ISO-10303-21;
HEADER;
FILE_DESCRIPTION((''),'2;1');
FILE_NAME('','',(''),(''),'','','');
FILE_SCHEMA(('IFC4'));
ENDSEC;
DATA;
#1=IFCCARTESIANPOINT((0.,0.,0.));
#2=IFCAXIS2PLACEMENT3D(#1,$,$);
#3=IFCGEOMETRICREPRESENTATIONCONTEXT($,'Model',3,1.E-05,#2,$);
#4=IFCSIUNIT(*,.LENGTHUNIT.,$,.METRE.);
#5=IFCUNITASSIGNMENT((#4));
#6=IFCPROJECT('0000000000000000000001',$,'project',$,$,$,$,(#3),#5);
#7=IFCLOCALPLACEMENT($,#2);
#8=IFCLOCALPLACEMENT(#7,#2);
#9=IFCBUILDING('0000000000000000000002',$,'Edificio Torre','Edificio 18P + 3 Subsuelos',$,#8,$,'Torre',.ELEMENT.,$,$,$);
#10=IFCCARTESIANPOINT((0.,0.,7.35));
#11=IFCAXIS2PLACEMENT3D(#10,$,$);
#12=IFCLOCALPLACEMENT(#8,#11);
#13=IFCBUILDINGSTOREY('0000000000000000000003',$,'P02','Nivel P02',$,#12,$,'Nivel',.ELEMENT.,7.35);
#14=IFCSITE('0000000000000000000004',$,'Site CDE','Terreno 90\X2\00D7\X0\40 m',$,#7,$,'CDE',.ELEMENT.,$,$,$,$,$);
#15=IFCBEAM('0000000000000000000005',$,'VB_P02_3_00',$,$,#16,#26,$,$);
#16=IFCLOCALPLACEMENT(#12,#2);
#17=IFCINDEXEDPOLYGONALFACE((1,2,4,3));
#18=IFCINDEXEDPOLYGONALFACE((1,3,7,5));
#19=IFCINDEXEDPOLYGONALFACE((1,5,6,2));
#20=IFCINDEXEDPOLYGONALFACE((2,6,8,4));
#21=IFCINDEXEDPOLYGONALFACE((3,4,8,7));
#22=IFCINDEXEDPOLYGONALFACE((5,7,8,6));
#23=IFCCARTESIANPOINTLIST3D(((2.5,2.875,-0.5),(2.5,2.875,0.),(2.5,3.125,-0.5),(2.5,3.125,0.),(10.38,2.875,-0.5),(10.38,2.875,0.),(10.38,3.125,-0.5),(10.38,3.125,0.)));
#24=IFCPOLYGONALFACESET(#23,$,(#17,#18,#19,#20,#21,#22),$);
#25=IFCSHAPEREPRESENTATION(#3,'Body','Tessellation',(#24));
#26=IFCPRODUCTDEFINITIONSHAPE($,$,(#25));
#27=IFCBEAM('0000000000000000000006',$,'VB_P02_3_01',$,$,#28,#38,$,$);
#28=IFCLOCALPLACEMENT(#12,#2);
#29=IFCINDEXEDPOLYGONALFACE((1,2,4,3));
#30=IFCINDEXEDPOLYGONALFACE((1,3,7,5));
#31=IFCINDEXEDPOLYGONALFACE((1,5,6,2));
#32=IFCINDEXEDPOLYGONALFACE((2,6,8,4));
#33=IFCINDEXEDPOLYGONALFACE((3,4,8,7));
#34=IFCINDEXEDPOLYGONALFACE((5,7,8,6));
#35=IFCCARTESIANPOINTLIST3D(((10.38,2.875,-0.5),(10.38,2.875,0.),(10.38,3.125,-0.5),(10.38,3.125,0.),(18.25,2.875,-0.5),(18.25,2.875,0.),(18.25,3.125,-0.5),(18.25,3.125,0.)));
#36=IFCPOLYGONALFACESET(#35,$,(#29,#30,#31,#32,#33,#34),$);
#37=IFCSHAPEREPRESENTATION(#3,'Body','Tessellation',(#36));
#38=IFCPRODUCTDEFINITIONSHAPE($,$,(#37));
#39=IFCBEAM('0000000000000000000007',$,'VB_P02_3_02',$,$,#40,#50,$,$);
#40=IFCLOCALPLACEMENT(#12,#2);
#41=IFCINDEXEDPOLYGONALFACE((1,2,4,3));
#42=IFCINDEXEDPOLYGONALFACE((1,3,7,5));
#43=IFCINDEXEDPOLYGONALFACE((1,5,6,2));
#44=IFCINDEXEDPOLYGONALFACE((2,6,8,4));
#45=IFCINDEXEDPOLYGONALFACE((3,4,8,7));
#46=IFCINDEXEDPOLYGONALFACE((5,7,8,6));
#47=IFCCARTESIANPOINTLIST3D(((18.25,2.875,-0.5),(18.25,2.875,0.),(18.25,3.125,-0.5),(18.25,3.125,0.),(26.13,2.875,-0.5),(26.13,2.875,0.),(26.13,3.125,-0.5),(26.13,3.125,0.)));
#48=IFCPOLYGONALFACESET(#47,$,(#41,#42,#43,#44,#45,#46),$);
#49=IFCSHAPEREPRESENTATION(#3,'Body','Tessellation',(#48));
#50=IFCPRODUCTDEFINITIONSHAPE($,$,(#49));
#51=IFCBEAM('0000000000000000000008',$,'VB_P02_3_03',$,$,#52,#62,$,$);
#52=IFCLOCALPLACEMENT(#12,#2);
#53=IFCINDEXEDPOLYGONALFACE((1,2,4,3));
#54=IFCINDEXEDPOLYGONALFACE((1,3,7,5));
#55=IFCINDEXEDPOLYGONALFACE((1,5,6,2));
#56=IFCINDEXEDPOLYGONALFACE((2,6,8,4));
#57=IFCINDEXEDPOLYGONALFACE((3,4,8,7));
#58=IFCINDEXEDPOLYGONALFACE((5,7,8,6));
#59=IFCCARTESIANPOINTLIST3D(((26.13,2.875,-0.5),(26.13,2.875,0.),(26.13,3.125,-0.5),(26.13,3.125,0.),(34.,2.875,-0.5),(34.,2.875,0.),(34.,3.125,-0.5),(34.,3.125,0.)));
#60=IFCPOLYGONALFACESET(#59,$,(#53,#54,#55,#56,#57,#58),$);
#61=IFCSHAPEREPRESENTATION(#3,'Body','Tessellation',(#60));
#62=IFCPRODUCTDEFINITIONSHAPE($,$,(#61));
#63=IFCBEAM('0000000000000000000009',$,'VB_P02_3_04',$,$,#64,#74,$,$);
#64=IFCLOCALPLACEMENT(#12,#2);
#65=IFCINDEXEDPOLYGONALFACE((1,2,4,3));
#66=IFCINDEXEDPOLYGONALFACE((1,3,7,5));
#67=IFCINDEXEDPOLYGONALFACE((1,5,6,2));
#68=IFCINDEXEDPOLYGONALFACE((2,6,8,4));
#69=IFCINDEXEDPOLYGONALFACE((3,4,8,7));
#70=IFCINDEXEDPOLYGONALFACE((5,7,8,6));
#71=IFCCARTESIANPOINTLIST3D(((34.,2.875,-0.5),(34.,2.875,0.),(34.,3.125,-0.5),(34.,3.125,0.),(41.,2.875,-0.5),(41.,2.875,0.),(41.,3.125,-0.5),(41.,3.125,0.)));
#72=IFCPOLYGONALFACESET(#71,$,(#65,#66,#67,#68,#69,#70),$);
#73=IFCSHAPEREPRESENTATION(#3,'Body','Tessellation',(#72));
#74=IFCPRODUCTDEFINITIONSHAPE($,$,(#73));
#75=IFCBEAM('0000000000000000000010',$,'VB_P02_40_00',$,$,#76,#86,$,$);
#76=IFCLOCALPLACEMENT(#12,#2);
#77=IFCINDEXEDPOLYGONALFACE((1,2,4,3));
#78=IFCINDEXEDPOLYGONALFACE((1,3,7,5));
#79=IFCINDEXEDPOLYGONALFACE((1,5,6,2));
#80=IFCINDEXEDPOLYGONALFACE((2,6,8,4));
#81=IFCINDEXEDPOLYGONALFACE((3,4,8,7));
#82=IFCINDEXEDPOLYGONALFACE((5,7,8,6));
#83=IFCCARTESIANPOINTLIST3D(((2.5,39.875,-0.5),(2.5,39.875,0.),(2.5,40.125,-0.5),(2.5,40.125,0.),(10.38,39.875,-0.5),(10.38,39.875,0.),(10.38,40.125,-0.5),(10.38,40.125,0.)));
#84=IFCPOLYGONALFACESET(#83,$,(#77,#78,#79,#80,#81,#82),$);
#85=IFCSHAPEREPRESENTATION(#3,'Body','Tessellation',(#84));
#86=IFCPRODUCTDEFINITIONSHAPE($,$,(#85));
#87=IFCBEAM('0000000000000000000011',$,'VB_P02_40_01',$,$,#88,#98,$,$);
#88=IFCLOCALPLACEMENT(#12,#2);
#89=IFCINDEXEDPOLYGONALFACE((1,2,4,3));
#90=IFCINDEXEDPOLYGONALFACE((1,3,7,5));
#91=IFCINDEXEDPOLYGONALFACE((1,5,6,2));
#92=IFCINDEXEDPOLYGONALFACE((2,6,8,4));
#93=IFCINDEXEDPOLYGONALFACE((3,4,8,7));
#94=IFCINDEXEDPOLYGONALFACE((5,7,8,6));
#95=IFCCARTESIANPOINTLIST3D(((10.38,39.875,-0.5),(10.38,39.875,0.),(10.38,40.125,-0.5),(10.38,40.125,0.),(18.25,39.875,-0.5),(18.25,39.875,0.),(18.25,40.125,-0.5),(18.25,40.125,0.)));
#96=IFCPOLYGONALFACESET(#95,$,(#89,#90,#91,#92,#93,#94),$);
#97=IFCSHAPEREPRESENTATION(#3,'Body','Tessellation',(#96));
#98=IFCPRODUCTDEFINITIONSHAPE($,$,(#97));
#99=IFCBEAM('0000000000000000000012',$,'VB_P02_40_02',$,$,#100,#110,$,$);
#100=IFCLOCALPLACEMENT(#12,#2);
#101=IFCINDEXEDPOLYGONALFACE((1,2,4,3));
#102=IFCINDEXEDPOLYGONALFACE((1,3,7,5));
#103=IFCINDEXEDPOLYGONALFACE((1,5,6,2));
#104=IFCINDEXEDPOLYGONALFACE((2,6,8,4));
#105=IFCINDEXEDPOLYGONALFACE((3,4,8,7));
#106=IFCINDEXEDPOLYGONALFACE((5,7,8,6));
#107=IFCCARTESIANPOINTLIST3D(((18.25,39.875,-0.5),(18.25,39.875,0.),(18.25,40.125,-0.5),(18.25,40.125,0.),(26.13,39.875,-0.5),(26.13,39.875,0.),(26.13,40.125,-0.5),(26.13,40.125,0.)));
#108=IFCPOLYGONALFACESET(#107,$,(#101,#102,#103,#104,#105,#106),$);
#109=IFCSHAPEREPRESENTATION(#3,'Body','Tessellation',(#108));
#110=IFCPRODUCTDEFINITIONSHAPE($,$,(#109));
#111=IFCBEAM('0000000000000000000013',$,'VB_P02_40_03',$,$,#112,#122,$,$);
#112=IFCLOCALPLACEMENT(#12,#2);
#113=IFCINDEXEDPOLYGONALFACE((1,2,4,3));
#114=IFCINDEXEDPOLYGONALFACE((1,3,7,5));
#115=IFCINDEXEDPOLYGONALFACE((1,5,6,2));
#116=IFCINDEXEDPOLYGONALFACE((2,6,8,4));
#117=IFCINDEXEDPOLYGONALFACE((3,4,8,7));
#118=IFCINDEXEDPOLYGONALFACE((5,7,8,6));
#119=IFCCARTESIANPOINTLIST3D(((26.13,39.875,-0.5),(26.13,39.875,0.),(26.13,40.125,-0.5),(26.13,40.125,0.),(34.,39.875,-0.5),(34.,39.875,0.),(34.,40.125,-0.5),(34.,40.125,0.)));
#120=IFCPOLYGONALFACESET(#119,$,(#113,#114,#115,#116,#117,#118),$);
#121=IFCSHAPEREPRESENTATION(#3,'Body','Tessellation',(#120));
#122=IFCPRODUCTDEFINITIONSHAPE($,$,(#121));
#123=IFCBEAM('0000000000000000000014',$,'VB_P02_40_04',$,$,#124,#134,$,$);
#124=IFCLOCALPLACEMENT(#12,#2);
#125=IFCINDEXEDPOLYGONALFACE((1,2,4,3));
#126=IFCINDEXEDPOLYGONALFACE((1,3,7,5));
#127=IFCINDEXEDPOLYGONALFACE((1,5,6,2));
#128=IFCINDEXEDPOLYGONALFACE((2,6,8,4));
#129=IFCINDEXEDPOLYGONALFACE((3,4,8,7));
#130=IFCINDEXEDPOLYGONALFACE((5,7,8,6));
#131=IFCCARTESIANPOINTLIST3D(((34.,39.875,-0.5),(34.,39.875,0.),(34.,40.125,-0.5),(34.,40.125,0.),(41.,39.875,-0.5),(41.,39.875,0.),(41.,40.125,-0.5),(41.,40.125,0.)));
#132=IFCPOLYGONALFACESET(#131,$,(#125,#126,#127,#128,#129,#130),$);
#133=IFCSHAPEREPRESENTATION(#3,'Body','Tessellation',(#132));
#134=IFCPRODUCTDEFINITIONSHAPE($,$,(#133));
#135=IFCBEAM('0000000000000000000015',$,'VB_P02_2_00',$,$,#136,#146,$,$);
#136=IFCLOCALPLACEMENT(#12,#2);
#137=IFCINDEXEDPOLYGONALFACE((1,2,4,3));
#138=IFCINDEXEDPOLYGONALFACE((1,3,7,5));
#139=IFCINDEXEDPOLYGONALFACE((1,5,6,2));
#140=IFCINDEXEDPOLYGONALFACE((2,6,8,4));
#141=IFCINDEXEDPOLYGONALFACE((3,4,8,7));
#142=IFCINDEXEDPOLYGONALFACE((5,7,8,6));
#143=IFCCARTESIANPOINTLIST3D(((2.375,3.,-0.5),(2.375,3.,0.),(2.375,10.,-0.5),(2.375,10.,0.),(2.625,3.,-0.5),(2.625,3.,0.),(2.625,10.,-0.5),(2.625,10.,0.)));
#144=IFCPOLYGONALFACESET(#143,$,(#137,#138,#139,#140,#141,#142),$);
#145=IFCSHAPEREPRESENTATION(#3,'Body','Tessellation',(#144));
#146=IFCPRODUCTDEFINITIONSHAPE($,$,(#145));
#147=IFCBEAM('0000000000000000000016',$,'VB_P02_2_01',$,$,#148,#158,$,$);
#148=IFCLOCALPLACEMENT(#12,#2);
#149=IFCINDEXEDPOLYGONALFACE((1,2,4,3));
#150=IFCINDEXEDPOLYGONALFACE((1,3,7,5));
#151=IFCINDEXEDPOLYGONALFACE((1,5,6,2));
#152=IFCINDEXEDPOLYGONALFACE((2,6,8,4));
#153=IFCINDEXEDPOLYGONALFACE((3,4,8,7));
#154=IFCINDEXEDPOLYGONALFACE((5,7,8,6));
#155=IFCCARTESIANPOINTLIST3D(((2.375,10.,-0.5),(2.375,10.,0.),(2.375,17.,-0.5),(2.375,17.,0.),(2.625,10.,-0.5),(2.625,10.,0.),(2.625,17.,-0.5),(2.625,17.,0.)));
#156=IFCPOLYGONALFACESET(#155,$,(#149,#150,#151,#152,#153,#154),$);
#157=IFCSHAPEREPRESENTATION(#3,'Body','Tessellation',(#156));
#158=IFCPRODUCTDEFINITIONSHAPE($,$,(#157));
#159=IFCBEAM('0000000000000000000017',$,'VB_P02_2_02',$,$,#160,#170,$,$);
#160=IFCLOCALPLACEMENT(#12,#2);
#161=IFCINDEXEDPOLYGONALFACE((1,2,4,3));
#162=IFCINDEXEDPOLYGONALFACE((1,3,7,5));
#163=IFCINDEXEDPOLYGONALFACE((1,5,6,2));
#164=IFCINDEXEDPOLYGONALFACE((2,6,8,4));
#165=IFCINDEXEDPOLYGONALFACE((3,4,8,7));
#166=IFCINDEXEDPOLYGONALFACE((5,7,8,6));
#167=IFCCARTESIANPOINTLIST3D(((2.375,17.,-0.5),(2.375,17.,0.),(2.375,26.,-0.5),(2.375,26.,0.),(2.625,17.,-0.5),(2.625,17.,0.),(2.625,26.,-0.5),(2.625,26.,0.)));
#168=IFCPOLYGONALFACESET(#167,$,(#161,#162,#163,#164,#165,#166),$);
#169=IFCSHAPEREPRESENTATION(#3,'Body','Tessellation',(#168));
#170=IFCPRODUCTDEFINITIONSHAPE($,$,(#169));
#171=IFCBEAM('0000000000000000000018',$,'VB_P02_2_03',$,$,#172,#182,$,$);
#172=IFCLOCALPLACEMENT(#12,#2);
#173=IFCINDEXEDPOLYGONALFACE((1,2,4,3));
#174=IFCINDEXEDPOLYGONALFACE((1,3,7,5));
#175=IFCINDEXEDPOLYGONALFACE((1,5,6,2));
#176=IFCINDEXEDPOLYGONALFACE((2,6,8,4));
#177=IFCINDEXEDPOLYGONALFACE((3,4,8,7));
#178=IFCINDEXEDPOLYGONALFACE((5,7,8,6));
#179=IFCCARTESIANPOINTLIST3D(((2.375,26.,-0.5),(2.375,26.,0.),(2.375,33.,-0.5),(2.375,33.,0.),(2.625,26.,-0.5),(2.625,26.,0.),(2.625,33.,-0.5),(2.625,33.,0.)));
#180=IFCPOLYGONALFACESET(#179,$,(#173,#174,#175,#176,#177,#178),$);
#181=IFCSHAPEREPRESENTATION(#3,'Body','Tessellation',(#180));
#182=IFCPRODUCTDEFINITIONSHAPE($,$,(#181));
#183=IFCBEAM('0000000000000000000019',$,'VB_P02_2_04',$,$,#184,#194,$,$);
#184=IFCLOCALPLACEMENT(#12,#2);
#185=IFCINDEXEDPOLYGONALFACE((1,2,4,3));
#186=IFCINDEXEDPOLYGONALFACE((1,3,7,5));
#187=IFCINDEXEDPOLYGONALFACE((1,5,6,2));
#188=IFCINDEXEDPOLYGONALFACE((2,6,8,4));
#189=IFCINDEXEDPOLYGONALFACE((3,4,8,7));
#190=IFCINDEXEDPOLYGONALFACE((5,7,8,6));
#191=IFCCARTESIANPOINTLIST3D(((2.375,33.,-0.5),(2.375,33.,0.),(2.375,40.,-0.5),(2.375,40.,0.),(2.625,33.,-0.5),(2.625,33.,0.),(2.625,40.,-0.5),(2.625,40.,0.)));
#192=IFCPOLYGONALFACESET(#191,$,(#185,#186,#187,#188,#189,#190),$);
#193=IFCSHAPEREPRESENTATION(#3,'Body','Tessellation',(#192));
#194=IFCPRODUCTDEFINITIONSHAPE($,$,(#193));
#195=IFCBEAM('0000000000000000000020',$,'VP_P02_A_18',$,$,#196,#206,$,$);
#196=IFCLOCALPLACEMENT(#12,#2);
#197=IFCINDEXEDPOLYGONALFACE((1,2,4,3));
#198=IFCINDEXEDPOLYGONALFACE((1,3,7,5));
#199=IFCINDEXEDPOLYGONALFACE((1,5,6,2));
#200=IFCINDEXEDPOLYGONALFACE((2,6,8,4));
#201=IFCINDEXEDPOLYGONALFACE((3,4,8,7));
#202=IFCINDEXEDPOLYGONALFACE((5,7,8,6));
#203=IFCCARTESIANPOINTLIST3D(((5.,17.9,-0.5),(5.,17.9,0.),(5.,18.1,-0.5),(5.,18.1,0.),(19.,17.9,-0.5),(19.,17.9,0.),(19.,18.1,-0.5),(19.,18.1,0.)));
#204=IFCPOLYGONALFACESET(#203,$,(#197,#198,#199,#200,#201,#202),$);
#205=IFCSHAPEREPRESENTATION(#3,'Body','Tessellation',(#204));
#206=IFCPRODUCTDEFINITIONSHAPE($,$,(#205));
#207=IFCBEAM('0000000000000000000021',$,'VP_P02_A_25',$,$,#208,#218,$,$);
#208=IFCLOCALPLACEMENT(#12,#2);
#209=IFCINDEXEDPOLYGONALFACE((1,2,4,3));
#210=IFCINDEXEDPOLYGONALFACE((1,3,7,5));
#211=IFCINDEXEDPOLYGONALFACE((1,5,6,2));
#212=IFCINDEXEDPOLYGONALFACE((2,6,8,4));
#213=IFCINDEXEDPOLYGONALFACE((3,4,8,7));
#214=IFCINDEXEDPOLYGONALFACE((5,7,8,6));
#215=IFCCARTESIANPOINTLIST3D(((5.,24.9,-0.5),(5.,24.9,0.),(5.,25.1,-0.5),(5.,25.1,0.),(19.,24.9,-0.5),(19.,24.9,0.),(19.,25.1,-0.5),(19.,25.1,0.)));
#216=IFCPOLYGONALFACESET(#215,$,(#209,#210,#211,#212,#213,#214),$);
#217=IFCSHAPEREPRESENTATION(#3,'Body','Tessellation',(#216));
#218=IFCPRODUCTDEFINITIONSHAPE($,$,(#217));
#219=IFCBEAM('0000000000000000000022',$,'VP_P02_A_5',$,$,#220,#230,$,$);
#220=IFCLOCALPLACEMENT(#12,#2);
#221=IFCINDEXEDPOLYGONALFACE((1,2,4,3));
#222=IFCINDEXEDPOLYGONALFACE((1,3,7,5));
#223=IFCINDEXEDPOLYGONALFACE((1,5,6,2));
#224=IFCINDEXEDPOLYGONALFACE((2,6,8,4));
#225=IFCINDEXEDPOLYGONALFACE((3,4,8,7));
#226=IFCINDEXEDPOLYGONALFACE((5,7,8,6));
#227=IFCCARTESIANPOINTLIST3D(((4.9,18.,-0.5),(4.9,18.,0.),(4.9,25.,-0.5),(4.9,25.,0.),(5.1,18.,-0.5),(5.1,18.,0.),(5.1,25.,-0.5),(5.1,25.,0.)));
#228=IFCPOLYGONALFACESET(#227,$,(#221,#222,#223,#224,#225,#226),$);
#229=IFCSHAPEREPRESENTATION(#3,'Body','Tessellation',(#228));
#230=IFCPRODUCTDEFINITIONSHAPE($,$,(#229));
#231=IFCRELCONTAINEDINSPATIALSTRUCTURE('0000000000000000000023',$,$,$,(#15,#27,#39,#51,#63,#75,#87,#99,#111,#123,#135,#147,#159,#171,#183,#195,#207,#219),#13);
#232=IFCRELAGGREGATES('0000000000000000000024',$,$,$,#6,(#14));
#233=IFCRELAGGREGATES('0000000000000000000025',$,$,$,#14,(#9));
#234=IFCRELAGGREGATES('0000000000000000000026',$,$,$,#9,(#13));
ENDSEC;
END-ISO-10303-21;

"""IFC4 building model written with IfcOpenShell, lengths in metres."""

from ifc_helpers import new_model, si_unit, frame, origin, origin_2d, place, context, project, spatial, rectangle, extrude, element, save


model = new_model("IFC4")

# Units and contexts
model_context = context("Model", 3, precision=1e-05, world=origin())
ifc_project = project(units=[si_unit("LENGTHUNIT", "METRE")], contexts=[model_context])

# Site, building, storey
site_placement = place(None, origin())
site = spatial("IfcSite", under=ifc_project, at=site_placement, Name="Site CDE", Description="Terreno 90×40 m", LongName="CDE", CompositionType="ELEMENT")
building_placement = place(site_placement, origin())
building = spatial("IfcBuilding", under=site, at=building_placement, Name="Edificio Torre", Description="Edificio 18P + 3 Subsuelos", LongName="Torre", CompositionType="ELEMENT")
storey_placement = place(building_placement, frame((0.0, 0.0, 7.35)))
storey = spatial("IfcBuildingStorey", under=building, at=storey_placement, Name="P02", Description="Nivel P02", LongName="Nivel", CompositionType="ELEMENT", Elevation=7.35)

# Beams
beam_1_placement = place(storey_placement, frame((6.44, 3.0, -0.5)))
element("IfcBeam", 1, at=beam_1_placement, inside=storey, Name="VB_P02_3_00", context=model_context, shape_type="SweptSolid", body=[
    extrude(rectangle(XDim=7.88, YDim=0.25, at=origin_2d()), origin(), (0.0, 0.0, 1.0), 0.5),
])
beam_2_placement = place(storey_placement, frame((14.315, 3.0, -0.5)))
element("IfcBeam", 2, at=beam_2_placement, inside=storey, Name="VB_P02_3_01", context=model_context, shape_type="SweptSolid", body=[
    extrude(rectangle(XDim=7.87, YDim=0.25, at=origin_2d()), origin(), (0.0, 0.0, 1.0), 0.5),
])
beam_3_placement = place(storey_placement, frame((22.19, 3.0, -0.5)))
element("IfcBeam", 3, at=beam_3_placement, inside=storey, Name="VB_P02_3_02", context=model_context, shape_type="SweptSolid", body=[
    extrude(rectangle(XDim=7.88, YDim=0.25, at=origin_2d()), origin(), (0.0, 0.0, 1.0), 0.5),
])
beam_4_placement = place(storey_placement, frame((30.065, 3.0, -0.5)))
element("IfcBeam", 4, at=beam_4_placement, inside=storey, Name="VB_P02_3_03", context=model_context, shape_type="SweptSolid", body=[
    extrude(rectangle(XDim=7.87, YDim=0.25, at=origin_2d()), origin(), (0.0, 0.0, 1.0), 0.5),
])
beam_5_placement = place(storey_placement, frame((37.5, 3.0, -0.5)))
element("IfcBeam", 5, at=beam_5_placement, inside=storey, Name="VB_P02_3_04", context=model_context, shape_type="SweptSolid", body=[
    extrude(rectangle(XDim=7.0, YDim=0.25, at=origin_2d()), origin(), (0.0, 0.0, 1.0), 0.5),
])
beam_6_placement = place(storey_placement, frame((6.44, 40.0, -0.5)))
element("IfcBeam", 6, at=beam_6_placement, inside=storey, Name="VB_P02_40_00", context=model_context, shape_type="SweptSolid", body=[
    extrude(rectangle(XDim=7.88, YDim=0.25, at=origin_2d()), origin(), (0.0, 0.0, 1.0), 0.5),
])
beam_7_placement = place(storey_placement, frame((14.315, 40.0, -0.5)))
element("IfcBeam", 7, at=beam_7_placement, inside=storey, Name="VB_P02_40_01", context=model_context, shape_type="SweptSolid", body=[
    extrude(rectangle(XDim=7.87, YDim=0.25, at=origin_2d()), origin(), (0.0, 0.0, 1.0), 0.5),
])
beam_8_placement = place(storey_placement, frame((22.19, 40.0, -0.5)))
element("IfcBeam", 8, at=beam_8_placement, inside=storey, Name="VB_P02_40_02", context=model_context, shape_type="SweptSolid", body=[
    extrude(rectangle(XDim=7.88, YDim=0.25, at=origin_2d()), origin(), (0.0, 0.0, 1.0), 0.5),
])
beam_9_placement = place(storey_placement, frame((30.065, 40.0, -0.5)))
element("IfcBeam", 9, at=beam_9_placement, inside=storey, Name="VB_P02_40_03", context=model_context, shape_type="SweptSolid", body=[
    extrude(rectangle(XDim=7.87, YDim=0.25, at=origin_2d()), origin(), (0.0, 0.0, 1.0), 0.5),
])
beam_10_placement = place(storey_placement, frame((37.5, 40.0, -0.5)))
element("IfcBeam", 10, at=beam_10_placement, inside=storey, Name="VB_P02_40_04", context=model_context, shape_type="SweptSolid", body=[
    extrude(rectangle(XDim=7.0, YDim=0.25, at=origin_2d()), origin(), (0.0, 0.0, 1.0), 0.5),
])
for number, where, name in (
    (11, (2.5, 6.5, -0.5), "VB_P02_2_00"),
    (12, (2.5, 13.5, -0.5), "VB_P02_2_01"),
):
    element("IfcBeam", number, at=place(storey_placement, frame(where)), inside=storey, Name=name, context=model_context, shape_type="SweptSolid", body=[
        extrude(rectangle(XDim=0.25, YDim=7.0, at=origin_2d()), origin(), (0.0, 0.0, 1.0), 0.5),
    ])
beam_11_placement = place(storey_placement, frame((2.5, 21.5, -0.5)))
element("IfcBeam", 13, at=beam_11_placement, inside=storey, Name="VB_P02_2_02", context=model_context, shape_type="SweptSolid", body=[
    extrude(rectangle(XDim=0.25, YDim=9.0, at=origin_2d()), origin(), (0.0, 0.0, 1.0), 0.5),
])
for number, where, name in (
    (14, (2.5, 29.5, -0.5), "VB_P02_2_03"),
    (15, (2.5, 36.5, -0.5), "VB_P02_2_04"),
):
    element("IfcBeam", number, at=place(storey_placement, frame(where)), inside=storey, Name=name, context=model_context, shape_type="SweptSolid", body=[
        extrude(rectangle(XDim=0.25, YDim=7.0, at=origin_2d()), origin(), (0.0, 0.0, 1.0), 0.5),
    ])
for number, where, name in (
    (16, (12.0, 18.0, -0.5), "VP_P02_A_18"),
    (17, (12.0, 25.0, -0.5), "VP_P02_A_25"),
):
    element("IfcBeam", number, at=place(storey_placement, frame(where)), inside=storey, Name=name, context=model_context, shape_type="SweptSolid", body=[
        extrude(rectangle(XDim=14.0, YDim=0.2, at=origin_2d()), origin(), (0.0, 0.0, 1.0), 0.5),
    ])
beam_12_placement = place(storey_placement, frame((5.0, 21.5, -0.5)))
element("IfcBeam", 18, at=beam_12_placement, inside=storey, Name="VP_P02_A_5", context=model_context, shape_type="SweptSolid", body=[
    extrude(rectangle(XDim=0.2, YDim=7.0, at=origin_2d()), origin(), (0.0, 0.0, 1.0), 0.5),
])

save(model, "model.ifc")
